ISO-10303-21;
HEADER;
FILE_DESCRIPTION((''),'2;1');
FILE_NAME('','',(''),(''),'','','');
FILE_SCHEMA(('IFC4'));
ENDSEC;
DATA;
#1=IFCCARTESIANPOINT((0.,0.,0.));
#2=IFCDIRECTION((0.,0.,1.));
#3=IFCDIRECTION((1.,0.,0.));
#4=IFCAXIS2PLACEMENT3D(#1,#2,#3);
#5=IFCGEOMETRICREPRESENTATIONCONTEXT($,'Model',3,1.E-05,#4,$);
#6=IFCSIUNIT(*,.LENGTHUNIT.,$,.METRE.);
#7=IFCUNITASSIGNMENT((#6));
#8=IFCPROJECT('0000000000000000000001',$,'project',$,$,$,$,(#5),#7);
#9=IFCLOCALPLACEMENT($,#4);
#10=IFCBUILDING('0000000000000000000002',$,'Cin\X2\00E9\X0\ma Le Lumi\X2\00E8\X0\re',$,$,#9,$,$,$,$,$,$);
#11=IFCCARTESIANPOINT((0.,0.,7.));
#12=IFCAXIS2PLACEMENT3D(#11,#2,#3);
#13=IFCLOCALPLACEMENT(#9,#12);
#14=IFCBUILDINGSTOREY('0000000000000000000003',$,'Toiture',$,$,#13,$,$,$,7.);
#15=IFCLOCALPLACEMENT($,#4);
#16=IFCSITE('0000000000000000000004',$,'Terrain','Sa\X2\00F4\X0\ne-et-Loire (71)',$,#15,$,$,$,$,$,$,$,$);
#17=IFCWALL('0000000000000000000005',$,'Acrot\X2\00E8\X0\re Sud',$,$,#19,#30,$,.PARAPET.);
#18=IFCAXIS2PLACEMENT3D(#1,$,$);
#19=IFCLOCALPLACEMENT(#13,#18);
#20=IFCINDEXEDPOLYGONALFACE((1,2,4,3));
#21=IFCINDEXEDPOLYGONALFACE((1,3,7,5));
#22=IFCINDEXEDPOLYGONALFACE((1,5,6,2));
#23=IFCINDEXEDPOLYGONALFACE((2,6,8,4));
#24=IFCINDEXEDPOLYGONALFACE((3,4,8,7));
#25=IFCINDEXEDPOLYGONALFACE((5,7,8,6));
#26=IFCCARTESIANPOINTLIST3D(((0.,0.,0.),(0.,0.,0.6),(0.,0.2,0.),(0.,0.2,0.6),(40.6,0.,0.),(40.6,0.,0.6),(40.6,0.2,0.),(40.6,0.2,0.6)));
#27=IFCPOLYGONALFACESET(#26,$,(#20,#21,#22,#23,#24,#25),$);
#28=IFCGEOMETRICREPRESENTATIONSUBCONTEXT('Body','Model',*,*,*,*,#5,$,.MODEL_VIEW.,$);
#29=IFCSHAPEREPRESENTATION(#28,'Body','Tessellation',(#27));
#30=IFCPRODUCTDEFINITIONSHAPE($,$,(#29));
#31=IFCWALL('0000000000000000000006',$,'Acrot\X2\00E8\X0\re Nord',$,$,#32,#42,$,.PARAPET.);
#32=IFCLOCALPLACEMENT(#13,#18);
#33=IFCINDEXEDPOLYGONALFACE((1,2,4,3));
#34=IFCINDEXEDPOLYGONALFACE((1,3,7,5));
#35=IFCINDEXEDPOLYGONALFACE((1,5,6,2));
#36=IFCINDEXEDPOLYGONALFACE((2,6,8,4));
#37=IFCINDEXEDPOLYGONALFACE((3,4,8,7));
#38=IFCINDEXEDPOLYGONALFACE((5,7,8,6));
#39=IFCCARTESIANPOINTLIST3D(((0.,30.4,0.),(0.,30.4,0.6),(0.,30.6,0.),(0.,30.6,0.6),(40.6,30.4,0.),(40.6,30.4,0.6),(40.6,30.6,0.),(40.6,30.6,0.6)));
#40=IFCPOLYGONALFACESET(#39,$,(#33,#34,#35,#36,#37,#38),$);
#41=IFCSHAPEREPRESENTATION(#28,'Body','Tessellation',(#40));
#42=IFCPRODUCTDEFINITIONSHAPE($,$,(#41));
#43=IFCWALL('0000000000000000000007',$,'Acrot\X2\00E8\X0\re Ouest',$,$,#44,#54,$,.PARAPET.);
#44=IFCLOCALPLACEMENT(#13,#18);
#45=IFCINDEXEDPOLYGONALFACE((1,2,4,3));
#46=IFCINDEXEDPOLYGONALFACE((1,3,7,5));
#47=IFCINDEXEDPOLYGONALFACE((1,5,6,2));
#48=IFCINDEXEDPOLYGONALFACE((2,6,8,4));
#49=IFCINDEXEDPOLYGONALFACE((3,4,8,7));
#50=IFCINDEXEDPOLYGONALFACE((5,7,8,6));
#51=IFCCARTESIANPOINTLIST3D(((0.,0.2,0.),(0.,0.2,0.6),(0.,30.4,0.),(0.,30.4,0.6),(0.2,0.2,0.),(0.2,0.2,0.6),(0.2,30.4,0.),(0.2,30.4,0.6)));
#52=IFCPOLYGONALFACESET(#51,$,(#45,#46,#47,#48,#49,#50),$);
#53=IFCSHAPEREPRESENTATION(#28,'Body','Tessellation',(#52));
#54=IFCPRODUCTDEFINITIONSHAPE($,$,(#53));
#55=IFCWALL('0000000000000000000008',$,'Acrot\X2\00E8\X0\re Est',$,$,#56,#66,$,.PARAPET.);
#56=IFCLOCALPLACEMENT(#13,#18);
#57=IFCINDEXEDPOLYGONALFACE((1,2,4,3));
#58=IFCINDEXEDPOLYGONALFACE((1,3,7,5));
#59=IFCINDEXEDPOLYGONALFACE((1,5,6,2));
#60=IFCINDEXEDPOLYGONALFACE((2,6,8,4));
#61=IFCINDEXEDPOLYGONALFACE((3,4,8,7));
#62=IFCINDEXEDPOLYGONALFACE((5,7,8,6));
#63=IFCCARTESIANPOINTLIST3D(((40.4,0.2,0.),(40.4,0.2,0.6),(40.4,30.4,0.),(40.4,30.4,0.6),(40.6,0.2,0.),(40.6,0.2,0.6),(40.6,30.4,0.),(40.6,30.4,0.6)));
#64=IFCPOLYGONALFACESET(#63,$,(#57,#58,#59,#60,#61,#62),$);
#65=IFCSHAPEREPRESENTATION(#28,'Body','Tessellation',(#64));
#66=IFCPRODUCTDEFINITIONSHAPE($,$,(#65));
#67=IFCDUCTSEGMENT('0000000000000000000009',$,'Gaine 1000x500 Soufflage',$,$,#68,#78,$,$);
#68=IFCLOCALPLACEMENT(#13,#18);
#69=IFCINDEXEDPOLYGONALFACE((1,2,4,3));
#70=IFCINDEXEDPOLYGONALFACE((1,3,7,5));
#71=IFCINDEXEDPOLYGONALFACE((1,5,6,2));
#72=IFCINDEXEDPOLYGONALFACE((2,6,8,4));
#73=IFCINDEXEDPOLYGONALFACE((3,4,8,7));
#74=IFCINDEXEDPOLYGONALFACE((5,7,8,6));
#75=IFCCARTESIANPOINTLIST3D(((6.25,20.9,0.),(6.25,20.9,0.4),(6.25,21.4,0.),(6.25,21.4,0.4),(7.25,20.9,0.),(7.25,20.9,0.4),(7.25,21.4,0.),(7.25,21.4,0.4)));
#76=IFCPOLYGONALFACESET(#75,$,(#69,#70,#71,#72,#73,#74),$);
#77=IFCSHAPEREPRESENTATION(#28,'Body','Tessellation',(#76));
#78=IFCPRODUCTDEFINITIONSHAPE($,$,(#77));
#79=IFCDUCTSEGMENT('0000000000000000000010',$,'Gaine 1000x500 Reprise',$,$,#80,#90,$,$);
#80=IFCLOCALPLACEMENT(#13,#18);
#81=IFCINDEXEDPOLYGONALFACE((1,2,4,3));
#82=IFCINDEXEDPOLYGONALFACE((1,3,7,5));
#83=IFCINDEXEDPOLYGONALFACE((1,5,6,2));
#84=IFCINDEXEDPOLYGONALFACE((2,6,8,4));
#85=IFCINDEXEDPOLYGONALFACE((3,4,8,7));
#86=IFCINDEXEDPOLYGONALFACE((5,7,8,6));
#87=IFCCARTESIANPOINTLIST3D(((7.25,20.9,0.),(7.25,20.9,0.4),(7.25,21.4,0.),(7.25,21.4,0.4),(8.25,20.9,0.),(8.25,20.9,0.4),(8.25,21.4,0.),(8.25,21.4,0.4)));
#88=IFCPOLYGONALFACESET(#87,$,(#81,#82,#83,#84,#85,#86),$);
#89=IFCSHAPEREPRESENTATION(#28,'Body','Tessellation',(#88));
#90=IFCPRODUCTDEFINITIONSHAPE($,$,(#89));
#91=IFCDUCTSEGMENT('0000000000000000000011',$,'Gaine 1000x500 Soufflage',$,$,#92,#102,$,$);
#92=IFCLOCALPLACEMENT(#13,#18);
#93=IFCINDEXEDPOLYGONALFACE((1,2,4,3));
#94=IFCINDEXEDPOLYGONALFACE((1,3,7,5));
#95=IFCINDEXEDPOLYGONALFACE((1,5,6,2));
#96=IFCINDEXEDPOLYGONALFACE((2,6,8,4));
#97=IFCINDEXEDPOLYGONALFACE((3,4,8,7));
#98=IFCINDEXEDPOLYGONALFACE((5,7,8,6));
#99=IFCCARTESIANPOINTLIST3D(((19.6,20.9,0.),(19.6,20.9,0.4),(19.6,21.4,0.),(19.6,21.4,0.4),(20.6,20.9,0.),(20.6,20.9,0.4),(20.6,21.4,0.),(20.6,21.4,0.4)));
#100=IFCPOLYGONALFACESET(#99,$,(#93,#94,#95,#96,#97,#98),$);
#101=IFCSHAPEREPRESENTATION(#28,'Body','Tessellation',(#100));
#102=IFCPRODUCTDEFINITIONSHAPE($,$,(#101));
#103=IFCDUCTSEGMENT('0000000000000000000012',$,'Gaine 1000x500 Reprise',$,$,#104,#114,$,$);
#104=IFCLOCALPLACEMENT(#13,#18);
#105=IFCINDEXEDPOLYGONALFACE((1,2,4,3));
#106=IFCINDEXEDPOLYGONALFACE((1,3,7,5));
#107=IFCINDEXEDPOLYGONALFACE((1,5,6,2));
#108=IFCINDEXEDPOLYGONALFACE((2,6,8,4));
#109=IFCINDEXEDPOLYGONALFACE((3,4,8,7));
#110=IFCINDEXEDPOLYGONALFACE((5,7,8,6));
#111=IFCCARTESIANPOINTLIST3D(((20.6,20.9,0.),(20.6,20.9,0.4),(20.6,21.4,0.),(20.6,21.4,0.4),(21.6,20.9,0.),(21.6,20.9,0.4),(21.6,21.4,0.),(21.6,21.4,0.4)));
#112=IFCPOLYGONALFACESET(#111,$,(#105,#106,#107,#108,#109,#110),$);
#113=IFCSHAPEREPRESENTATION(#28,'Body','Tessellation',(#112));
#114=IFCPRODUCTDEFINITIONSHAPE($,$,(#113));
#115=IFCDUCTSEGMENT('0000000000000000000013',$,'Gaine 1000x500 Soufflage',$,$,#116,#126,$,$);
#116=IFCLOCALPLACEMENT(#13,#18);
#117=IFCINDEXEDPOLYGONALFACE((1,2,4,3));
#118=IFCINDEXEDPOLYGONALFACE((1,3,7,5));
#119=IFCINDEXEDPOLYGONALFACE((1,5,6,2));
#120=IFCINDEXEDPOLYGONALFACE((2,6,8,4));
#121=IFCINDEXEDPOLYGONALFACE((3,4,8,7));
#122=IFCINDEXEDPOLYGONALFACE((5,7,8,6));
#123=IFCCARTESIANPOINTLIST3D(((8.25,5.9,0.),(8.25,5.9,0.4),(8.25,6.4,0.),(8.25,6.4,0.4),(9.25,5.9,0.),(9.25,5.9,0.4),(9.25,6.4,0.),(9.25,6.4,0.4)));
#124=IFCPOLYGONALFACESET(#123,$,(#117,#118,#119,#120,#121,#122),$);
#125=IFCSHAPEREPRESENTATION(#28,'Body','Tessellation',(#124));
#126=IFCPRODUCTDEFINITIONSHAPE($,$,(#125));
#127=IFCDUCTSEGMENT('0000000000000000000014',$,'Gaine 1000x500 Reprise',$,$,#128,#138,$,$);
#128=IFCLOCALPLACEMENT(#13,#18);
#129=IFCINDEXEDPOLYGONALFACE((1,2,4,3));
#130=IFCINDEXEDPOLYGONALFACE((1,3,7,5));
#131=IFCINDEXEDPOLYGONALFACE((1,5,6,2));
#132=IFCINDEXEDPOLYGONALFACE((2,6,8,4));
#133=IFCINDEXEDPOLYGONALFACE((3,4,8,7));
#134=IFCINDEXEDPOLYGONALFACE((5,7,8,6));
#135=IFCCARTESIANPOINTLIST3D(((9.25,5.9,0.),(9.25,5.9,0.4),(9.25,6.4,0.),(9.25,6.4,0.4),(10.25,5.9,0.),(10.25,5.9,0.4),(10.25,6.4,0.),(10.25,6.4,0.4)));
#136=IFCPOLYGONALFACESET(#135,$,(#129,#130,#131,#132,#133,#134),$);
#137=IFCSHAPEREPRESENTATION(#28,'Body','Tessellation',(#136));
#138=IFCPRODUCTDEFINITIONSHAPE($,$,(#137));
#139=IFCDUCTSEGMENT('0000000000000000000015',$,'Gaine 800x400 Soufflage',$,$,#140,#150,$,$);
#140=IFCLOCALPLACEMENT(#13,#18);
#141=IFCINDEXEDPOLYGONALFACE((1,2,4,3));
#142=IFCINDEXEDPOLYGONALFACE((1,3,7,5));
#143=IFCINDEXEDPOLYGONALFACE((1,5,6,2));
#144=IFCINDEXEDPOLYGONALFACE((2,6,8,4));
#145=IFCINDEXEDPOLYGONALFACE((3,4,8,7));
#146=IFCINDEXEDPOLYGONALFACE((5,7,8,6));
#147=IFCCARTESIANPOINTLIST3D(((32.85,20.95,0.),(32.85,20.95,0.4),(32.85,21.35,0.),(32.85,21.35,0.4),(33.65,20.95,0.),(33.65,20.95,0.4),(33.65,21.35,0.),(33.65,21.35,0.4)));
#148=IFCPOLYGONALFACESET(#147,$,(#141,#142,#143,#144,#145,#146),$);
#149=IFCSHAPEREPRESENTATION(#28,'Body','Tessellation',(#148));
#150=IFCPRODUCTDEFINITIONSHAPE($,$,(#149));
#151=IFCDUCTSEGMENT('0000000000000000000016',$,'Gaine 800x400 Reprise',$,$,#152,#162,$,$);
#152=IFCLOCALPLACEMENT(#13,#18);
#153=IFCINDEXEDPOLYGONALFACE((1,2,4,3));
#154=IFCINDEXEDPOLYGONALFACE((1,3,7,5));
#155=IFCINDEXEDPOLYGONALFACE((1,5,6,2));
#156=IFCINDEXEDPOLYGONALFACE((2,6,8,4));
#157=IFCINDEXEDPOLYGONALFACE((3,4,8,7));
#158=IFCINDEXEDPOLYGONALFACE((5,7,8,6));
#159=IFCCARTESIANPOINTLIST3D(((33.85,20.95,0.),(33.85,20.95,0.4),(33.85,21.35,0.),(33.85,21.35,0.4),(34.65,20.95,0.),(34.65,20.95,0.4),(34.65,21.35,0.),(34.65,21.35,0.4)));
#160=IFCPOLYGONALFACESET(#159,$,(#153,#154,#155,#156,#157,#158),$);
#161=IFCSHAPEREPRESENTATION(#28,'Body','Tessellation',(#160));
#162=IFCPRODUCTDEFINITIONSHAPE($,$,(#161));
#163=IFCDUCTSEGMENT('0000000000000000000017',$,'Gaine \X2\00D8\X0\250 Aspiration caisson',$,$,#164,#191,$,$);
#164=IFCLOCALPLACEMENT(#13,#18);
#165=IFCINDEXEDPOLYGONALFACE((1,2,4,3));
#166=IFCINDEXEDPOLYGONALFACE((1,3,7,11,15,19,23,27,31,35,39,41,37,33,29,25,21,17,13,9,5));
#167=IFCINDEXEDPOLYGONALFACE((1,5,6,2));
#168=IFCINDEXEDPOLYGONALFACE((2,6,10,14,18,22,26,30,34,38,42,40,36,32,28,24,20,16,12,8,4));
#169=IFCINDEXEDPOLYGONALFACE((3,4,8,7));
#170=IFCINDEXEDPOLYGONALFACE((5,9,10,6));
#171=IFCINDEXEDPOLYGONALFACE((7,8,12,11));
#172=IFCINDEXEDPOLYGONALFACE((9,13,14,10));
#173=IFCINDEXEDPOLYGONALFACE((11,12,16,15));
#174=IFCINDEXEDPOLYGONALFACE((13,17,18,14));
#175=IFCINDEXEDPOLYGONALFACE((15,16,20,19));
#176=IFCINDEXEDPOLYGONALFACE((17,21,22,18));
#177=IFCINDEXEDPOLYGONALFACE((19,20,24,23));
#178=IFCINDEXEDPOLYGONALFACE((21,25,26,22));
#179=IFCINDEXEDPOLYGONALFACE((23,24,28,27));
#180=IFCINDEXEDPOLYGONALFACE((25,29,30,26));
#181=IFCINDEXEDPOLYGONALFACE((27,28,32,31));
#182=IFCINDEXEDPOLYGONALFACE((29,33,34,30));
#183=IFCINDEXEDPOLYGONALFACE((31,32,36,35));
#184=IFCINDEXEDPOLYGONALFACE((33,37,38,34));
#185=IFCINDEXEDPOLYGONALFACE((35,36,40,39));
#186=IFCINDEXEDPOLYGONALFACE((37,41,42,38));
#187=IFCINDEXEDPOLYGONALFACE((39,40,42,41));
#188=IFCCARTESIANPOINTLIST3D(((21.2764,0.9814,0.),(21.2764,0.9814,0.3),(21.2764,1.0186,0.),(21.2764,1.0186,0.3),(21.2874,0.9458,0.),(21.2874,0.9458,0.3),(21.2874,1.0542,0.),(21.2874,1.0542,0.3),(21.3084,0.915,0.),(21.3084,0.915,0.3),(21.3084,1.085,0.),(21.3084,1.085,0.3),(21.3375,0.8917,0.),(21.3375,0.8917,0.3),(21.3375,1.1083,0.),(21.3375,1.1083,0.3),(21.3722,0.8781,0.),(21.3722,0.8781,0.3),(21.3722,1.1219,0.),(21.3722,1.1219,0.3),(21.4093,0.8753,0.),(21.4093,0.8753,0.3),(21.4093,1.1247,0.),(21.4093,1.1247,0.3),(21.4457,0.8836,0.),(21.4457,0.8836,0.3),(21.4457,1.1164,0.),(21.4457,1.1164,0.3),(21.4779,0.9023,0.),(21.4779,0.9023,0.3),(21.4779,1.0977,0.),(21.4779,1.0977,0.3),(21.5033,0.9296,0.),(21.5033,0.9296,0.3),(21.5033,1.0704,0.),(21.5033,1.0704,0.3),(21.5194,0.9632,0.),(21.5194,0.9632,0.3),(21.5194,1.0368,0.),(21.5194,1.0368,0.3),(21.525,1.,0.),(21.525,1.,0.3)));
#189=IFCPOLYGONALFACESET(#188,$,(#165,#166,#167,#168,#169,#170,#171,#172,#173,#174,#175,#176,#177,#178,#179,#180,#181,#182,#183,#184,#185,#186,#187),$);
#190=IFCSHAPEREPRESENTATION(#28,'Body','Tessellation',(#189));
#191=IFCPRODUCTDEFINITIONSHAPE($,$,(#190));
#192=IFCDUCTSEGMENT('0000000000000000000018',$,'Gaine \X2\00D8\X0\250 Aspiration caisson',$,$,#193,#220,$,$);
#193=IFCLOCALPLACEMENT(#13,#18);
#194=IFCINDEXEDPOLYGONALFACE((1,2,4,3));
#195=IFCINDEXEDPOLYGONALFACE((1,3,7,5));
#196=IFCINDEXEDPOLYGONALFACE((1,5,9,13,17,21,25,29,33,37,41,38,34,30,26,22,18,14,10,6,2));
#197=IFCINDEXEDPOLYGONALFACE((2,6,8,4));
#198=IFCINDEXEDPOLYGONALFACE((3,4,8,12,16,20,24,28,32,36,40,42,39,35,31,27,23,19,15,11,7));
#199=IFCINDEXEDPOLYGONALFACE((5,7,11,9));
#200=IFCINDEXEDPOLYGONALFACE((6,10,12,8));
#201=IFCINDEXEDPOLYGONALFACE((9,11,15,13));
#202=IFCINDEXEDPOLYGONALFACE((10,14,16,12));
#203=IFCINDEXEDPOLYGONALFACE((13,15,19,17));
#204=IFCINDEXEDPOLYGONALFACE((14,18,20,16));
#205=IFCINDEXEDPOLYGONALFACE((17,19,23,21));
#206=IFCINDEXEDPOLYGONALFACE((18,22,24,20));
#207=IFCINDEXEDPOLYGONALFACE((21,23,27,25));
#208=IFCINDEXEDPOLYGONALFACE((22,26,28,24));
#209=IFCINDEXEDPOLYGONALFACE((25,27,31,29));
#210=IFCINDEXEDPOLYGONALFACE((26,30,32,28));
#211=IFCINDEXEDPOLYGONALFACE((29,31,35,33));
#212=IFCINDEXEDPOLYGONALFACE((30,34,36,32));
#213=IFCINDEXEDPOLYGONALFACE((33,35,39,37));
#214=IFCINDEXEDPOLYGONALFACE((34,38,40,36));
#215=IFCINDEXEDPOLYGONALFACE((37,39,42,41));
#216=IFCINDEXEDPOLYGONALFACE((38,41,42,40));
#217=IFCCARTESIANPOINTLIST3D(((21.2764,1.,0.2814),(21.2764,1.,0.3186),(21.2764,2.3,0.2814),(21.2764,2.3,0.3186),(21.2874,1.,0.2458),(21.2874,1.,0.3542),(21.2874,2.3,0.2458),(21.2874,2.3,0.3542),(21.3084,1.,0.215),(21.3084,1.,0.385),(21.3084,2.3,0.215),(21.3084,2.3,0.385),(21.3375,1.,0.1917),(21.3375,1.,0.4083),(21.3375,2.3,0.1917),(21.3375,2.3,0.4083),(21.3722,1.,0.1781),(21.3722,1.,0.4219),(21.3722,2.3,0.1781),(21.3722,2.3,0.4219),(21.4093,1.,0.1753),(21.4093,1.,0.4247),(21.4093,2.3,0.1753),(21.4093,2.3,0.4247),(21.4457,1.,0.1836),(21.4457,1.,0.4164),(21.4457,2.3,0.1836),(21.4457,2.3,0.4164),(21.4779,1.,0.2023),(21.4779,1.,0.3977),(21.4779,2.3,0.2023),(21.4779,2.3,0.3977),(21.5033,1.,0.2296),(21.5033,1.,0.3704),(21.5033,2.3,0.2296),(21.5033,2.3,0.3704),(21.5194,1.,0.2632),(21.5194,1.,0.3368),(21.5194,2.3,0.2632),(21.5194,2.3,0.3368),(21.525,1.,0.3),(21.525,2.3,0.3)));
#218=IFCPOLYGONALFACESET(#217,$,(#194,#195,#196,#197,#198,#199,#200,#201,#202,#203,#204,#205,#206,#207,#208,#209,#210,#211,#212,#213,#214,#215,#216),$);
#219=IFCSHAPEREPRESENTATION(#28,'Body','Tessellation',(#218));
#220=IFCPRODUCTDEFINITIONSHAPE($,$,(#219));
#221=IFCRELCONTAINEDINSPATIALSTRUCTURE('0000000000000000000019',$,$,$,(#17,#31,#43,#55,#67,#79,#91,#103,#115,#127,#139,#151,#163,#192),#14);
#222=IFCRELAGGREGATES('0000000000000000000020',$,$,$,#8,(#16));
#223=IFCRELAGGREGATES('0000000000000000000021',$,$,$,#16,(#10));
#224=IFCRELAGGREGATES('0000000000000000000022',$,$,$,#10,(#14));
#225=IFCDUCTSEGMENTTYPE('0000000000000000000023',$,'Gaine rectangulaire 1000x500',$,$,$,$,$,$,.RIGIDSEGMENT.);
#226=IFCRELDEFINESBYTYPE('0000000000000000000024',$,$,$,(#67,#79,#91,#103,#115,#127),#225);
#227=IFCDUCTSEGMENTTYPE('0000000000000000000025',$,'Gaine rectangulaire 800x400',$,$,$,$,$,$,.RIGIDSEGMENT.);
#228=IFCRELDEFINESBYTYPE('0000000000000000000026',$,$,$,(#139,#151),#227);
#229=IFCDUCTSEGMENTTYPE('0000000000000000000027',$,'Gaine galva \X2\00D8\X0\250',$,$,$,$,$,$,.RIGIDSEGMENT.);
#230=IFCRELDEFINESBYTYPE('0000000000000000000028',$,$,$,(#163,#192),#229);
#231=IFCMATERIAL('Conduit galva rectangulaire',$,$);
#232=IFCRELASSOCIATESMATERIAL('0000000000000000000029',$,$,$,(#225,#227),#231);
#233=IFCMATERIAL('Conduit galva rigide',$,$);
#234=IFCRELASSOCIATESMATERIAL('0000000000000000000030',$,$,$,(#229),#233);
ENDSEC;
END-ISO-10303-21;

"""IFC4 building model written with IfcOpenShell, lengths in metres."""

from ifc_helpers import new_model, si_unit, frame, frame_2d, origin_with_axes, origin_2d, place, context, subcontext, project, spatial, rectangle, circle, extrude, material, type_object, element, save


model = new_model("IFC4")

# Units and contexts
model_context = context("Model", 3, precision=1e-05, world=origin_with_axes())
body_context = subcontext(model_context, "Body", "Model", "MODEL_VIEW")
ifc_project = project(units=[si_unit("LENGTHUNIT", "METRE")], contexts=[model_context])

# Site, building, storey
site_placement = place(None, origin_with_axes())
site = spatial("IfcSite", under=ifc_project, at=site_placement, Name="Terrain", Description="Saône-et-Loire (71)")
building_placement = place(None, origin_with_axes())
building = spatial("IfcBuilding", under=site, at=building_placement, Name="Cinéma Le Lumière")
storey_placement = place(building_placement, frame((0.0, 0.0, 7.0), z_axis=(0.0, 0.0, 1.0), x_axis=(1.0, 0.0, 0.0)))
storey = spatial("IfcBuildingStorey", under=building, at=storey_placement, Name="Toiture", Elevation=7.0)

# Walls
for number, where, z_axis, x_axis, name in (
    (1, (0.0, 0.0, 0.0), (0.0, 0.0, 1.0), (1.0, 0.0, 0.0), "Acrotère Sud"),
    (2, (0.0, 30.4, 0.0), (0.0, 0.0, 1.0), (1.0, 0.0, 0.0), "Acrotère Nord"),
):
    element("IfcWall", number, at=place(storey_placement, frame(where, z_axis=z_axis, x_axis=x_axis)), inside=storey, Name=name, PredefinedType="PARAPET", context=body_context, shape_type="SweptSolid", body=[
        extrude(rectangle(XDim=40.6, YDim=0.2, at=frame_2d((20.3, 0.1))), origin_with_axes(), (0.0, 0.0, 1.0), 0.6),
    ])
for number, where, z_axis, x_axis, name in (
    (3, (0.0, 0.2, 0.0), (0.0, 0.0, 1.0), (1.0, 0.0, 0.0), "Acrotère Ouest"),
    (4, (40.4, 0.2, 0.0), (0.0, 0.0, 1.0), (1.0, 0.0, 0.0), "Acrotère Est"),
):
    element("IfcWall", number, at=place(storey_placement, frame(where, z_axis=z_axis, x_axis=x_axis)), inside=storey, Name=name, PredefinedType="PARAPET", context=body_context, shape_type="SweptSolid", body=[
        extrude(rectangle(XDim=0.2, YDim=30.2, at=frame_2d((0.1, 15.1))), origin_with_axes(), (0.0, 0.0, 1.0), 0.6),
    ])

# Duct segments
ifc_material_1 = material(Name="Conduit galva rectangulaire")
duct_segment_type_1 = type_object("IfcDuctSegmentType", Name="Gaine rectangulaire 1000x500", PredefinedType="RIGIDSEGMENT", material=ifc_material_1)
for number, where, z_axis, x_axis, name in (
    (5, (6.75, 21.15, 0.4), (0.0, 0.0, -1.0), (1.0, 0.0, 0.0), "Gaine 1000x500 Soufflage"),
    (6, (7.75, 21.15, 0.4), (0.0, 0.0, -1.0), (1.0, 0.0, 0.0), "Gaine 1000x500 Reprise"),
    (7, (20.1, 21.15, 0.4), (0.0, 0.0, -1.0), (1.0, 0.0, 0.0), "Gaine 1000x500 Soufflage"),
    (8, (21.1, 21.15, 0.4), (0.0, 0.0, -1.0), (1.0, 0.0, 0.0), "Gaine 1000x500 Reprise"),
    (9, (8.75, 6.15, 0.4), (0.0, 0.0, -1.0), (1.0, 0.0, 0.0), "Gaine 1000x500 Soufflage"),
    (10, (9.75, 6.15, 0.4), (0.0, 0.0, -1.0), (1.0, 0.0, 0.0), "Gaine 1000x500 Reprise"),
):
    element("IfcDuctSegment", number, at=place(storey_placement, frame(where, z_axis=z_axis, x_axis=x_axis)), inside=storey, type_object=duct_segment_type_1, Name=name, context=body_context, shape_type="SweptSolid", body=[
        extrude(rectangle(XDim=1.0, YDim=0.5, at=origin_2d()), origin_with_axes(), (0.0, 0.0, 1.0), 0.4),
    ])
duct_segment_type_2 = type_object("IfcDuctSegmentType", Name="Gaine rectangulaire 800x400", PredefinedType="RIGIDSEGMENT", material=ifc_material_1)
for number, where, z_axis, x_axis, name in (
    (11, (33.25, 21.15, 0.4), (0.0, 0.0, -1.0), (1.0, 0.0, 0.0), "Gaine 800x400 Soufflage"),
    (12, (34.25, 21.15, 0.4), (0.0, 0.0, -1.0), (1.0, 0.0, 0.0), "Gaine 800x400 Reprise"),
):
    element("IfcDuctSegment", number, at=place(storey_placement, frame(where, z_axis=z_axis, x_axis=x_axis)), inside=storey, type_object=duct_segment_type_2, Name=name, context=body_context, shape_type="SweptSolid", body=[
        extrude(rectangle(XDim=0.8, YDim=0.4, at=origin_2d()), origin_with_axes(), (0.0, 0.0, 1.0), 0.4),
    ])
ifc_material_2 = material(Name="Conduit galva rigide")
duct_segment_type_3 = type_object("IfcDuctSegmentType", Name="Gaine galva Ø250", PredefinedType="RIGIDSEGMENT", material=ifc_material_2)
duct_segment_1_placement = place(storey_placement, frame((21.4, 1.0, 0.0), z_axis=(0.0, 0.0, 1.0), x_axis=(1.0, 0.0, 0.0)))
element("IfcDuctSegment", 13, at=duct_segment_1_placement, inside=storey, type_object=duct_segment_type_3, Name="Gaine Ø250 Aspiration caisson", context=body_context, shape_type="SweptSolid", body=[
    extrude(circle(Radius=0.125), origin_with_axes(), (0.0, 0.0, 1.0), 0.3),
])
duct_segment_2_placement = place(storey_placement, frame((21.4, 1.0, 0.3), z_axis=(0.0, 1.0, 0.0), x_axis=(1.0, 0.0, 0.0)))
element("IfcDuctSegment", 14, at=duct_segment_2_placement, inside=storey, type_object=duct_segment_type_3, Name="Gaine Ø250 Aspiration caisson", context=body_context, shape_type="SweptSolid", body=[
    extrude(circle(Radius=0.125), origin_with_axes(), (0.0, 0.0, 1.0), 1.3),
])

save(model, "model.ifc")
